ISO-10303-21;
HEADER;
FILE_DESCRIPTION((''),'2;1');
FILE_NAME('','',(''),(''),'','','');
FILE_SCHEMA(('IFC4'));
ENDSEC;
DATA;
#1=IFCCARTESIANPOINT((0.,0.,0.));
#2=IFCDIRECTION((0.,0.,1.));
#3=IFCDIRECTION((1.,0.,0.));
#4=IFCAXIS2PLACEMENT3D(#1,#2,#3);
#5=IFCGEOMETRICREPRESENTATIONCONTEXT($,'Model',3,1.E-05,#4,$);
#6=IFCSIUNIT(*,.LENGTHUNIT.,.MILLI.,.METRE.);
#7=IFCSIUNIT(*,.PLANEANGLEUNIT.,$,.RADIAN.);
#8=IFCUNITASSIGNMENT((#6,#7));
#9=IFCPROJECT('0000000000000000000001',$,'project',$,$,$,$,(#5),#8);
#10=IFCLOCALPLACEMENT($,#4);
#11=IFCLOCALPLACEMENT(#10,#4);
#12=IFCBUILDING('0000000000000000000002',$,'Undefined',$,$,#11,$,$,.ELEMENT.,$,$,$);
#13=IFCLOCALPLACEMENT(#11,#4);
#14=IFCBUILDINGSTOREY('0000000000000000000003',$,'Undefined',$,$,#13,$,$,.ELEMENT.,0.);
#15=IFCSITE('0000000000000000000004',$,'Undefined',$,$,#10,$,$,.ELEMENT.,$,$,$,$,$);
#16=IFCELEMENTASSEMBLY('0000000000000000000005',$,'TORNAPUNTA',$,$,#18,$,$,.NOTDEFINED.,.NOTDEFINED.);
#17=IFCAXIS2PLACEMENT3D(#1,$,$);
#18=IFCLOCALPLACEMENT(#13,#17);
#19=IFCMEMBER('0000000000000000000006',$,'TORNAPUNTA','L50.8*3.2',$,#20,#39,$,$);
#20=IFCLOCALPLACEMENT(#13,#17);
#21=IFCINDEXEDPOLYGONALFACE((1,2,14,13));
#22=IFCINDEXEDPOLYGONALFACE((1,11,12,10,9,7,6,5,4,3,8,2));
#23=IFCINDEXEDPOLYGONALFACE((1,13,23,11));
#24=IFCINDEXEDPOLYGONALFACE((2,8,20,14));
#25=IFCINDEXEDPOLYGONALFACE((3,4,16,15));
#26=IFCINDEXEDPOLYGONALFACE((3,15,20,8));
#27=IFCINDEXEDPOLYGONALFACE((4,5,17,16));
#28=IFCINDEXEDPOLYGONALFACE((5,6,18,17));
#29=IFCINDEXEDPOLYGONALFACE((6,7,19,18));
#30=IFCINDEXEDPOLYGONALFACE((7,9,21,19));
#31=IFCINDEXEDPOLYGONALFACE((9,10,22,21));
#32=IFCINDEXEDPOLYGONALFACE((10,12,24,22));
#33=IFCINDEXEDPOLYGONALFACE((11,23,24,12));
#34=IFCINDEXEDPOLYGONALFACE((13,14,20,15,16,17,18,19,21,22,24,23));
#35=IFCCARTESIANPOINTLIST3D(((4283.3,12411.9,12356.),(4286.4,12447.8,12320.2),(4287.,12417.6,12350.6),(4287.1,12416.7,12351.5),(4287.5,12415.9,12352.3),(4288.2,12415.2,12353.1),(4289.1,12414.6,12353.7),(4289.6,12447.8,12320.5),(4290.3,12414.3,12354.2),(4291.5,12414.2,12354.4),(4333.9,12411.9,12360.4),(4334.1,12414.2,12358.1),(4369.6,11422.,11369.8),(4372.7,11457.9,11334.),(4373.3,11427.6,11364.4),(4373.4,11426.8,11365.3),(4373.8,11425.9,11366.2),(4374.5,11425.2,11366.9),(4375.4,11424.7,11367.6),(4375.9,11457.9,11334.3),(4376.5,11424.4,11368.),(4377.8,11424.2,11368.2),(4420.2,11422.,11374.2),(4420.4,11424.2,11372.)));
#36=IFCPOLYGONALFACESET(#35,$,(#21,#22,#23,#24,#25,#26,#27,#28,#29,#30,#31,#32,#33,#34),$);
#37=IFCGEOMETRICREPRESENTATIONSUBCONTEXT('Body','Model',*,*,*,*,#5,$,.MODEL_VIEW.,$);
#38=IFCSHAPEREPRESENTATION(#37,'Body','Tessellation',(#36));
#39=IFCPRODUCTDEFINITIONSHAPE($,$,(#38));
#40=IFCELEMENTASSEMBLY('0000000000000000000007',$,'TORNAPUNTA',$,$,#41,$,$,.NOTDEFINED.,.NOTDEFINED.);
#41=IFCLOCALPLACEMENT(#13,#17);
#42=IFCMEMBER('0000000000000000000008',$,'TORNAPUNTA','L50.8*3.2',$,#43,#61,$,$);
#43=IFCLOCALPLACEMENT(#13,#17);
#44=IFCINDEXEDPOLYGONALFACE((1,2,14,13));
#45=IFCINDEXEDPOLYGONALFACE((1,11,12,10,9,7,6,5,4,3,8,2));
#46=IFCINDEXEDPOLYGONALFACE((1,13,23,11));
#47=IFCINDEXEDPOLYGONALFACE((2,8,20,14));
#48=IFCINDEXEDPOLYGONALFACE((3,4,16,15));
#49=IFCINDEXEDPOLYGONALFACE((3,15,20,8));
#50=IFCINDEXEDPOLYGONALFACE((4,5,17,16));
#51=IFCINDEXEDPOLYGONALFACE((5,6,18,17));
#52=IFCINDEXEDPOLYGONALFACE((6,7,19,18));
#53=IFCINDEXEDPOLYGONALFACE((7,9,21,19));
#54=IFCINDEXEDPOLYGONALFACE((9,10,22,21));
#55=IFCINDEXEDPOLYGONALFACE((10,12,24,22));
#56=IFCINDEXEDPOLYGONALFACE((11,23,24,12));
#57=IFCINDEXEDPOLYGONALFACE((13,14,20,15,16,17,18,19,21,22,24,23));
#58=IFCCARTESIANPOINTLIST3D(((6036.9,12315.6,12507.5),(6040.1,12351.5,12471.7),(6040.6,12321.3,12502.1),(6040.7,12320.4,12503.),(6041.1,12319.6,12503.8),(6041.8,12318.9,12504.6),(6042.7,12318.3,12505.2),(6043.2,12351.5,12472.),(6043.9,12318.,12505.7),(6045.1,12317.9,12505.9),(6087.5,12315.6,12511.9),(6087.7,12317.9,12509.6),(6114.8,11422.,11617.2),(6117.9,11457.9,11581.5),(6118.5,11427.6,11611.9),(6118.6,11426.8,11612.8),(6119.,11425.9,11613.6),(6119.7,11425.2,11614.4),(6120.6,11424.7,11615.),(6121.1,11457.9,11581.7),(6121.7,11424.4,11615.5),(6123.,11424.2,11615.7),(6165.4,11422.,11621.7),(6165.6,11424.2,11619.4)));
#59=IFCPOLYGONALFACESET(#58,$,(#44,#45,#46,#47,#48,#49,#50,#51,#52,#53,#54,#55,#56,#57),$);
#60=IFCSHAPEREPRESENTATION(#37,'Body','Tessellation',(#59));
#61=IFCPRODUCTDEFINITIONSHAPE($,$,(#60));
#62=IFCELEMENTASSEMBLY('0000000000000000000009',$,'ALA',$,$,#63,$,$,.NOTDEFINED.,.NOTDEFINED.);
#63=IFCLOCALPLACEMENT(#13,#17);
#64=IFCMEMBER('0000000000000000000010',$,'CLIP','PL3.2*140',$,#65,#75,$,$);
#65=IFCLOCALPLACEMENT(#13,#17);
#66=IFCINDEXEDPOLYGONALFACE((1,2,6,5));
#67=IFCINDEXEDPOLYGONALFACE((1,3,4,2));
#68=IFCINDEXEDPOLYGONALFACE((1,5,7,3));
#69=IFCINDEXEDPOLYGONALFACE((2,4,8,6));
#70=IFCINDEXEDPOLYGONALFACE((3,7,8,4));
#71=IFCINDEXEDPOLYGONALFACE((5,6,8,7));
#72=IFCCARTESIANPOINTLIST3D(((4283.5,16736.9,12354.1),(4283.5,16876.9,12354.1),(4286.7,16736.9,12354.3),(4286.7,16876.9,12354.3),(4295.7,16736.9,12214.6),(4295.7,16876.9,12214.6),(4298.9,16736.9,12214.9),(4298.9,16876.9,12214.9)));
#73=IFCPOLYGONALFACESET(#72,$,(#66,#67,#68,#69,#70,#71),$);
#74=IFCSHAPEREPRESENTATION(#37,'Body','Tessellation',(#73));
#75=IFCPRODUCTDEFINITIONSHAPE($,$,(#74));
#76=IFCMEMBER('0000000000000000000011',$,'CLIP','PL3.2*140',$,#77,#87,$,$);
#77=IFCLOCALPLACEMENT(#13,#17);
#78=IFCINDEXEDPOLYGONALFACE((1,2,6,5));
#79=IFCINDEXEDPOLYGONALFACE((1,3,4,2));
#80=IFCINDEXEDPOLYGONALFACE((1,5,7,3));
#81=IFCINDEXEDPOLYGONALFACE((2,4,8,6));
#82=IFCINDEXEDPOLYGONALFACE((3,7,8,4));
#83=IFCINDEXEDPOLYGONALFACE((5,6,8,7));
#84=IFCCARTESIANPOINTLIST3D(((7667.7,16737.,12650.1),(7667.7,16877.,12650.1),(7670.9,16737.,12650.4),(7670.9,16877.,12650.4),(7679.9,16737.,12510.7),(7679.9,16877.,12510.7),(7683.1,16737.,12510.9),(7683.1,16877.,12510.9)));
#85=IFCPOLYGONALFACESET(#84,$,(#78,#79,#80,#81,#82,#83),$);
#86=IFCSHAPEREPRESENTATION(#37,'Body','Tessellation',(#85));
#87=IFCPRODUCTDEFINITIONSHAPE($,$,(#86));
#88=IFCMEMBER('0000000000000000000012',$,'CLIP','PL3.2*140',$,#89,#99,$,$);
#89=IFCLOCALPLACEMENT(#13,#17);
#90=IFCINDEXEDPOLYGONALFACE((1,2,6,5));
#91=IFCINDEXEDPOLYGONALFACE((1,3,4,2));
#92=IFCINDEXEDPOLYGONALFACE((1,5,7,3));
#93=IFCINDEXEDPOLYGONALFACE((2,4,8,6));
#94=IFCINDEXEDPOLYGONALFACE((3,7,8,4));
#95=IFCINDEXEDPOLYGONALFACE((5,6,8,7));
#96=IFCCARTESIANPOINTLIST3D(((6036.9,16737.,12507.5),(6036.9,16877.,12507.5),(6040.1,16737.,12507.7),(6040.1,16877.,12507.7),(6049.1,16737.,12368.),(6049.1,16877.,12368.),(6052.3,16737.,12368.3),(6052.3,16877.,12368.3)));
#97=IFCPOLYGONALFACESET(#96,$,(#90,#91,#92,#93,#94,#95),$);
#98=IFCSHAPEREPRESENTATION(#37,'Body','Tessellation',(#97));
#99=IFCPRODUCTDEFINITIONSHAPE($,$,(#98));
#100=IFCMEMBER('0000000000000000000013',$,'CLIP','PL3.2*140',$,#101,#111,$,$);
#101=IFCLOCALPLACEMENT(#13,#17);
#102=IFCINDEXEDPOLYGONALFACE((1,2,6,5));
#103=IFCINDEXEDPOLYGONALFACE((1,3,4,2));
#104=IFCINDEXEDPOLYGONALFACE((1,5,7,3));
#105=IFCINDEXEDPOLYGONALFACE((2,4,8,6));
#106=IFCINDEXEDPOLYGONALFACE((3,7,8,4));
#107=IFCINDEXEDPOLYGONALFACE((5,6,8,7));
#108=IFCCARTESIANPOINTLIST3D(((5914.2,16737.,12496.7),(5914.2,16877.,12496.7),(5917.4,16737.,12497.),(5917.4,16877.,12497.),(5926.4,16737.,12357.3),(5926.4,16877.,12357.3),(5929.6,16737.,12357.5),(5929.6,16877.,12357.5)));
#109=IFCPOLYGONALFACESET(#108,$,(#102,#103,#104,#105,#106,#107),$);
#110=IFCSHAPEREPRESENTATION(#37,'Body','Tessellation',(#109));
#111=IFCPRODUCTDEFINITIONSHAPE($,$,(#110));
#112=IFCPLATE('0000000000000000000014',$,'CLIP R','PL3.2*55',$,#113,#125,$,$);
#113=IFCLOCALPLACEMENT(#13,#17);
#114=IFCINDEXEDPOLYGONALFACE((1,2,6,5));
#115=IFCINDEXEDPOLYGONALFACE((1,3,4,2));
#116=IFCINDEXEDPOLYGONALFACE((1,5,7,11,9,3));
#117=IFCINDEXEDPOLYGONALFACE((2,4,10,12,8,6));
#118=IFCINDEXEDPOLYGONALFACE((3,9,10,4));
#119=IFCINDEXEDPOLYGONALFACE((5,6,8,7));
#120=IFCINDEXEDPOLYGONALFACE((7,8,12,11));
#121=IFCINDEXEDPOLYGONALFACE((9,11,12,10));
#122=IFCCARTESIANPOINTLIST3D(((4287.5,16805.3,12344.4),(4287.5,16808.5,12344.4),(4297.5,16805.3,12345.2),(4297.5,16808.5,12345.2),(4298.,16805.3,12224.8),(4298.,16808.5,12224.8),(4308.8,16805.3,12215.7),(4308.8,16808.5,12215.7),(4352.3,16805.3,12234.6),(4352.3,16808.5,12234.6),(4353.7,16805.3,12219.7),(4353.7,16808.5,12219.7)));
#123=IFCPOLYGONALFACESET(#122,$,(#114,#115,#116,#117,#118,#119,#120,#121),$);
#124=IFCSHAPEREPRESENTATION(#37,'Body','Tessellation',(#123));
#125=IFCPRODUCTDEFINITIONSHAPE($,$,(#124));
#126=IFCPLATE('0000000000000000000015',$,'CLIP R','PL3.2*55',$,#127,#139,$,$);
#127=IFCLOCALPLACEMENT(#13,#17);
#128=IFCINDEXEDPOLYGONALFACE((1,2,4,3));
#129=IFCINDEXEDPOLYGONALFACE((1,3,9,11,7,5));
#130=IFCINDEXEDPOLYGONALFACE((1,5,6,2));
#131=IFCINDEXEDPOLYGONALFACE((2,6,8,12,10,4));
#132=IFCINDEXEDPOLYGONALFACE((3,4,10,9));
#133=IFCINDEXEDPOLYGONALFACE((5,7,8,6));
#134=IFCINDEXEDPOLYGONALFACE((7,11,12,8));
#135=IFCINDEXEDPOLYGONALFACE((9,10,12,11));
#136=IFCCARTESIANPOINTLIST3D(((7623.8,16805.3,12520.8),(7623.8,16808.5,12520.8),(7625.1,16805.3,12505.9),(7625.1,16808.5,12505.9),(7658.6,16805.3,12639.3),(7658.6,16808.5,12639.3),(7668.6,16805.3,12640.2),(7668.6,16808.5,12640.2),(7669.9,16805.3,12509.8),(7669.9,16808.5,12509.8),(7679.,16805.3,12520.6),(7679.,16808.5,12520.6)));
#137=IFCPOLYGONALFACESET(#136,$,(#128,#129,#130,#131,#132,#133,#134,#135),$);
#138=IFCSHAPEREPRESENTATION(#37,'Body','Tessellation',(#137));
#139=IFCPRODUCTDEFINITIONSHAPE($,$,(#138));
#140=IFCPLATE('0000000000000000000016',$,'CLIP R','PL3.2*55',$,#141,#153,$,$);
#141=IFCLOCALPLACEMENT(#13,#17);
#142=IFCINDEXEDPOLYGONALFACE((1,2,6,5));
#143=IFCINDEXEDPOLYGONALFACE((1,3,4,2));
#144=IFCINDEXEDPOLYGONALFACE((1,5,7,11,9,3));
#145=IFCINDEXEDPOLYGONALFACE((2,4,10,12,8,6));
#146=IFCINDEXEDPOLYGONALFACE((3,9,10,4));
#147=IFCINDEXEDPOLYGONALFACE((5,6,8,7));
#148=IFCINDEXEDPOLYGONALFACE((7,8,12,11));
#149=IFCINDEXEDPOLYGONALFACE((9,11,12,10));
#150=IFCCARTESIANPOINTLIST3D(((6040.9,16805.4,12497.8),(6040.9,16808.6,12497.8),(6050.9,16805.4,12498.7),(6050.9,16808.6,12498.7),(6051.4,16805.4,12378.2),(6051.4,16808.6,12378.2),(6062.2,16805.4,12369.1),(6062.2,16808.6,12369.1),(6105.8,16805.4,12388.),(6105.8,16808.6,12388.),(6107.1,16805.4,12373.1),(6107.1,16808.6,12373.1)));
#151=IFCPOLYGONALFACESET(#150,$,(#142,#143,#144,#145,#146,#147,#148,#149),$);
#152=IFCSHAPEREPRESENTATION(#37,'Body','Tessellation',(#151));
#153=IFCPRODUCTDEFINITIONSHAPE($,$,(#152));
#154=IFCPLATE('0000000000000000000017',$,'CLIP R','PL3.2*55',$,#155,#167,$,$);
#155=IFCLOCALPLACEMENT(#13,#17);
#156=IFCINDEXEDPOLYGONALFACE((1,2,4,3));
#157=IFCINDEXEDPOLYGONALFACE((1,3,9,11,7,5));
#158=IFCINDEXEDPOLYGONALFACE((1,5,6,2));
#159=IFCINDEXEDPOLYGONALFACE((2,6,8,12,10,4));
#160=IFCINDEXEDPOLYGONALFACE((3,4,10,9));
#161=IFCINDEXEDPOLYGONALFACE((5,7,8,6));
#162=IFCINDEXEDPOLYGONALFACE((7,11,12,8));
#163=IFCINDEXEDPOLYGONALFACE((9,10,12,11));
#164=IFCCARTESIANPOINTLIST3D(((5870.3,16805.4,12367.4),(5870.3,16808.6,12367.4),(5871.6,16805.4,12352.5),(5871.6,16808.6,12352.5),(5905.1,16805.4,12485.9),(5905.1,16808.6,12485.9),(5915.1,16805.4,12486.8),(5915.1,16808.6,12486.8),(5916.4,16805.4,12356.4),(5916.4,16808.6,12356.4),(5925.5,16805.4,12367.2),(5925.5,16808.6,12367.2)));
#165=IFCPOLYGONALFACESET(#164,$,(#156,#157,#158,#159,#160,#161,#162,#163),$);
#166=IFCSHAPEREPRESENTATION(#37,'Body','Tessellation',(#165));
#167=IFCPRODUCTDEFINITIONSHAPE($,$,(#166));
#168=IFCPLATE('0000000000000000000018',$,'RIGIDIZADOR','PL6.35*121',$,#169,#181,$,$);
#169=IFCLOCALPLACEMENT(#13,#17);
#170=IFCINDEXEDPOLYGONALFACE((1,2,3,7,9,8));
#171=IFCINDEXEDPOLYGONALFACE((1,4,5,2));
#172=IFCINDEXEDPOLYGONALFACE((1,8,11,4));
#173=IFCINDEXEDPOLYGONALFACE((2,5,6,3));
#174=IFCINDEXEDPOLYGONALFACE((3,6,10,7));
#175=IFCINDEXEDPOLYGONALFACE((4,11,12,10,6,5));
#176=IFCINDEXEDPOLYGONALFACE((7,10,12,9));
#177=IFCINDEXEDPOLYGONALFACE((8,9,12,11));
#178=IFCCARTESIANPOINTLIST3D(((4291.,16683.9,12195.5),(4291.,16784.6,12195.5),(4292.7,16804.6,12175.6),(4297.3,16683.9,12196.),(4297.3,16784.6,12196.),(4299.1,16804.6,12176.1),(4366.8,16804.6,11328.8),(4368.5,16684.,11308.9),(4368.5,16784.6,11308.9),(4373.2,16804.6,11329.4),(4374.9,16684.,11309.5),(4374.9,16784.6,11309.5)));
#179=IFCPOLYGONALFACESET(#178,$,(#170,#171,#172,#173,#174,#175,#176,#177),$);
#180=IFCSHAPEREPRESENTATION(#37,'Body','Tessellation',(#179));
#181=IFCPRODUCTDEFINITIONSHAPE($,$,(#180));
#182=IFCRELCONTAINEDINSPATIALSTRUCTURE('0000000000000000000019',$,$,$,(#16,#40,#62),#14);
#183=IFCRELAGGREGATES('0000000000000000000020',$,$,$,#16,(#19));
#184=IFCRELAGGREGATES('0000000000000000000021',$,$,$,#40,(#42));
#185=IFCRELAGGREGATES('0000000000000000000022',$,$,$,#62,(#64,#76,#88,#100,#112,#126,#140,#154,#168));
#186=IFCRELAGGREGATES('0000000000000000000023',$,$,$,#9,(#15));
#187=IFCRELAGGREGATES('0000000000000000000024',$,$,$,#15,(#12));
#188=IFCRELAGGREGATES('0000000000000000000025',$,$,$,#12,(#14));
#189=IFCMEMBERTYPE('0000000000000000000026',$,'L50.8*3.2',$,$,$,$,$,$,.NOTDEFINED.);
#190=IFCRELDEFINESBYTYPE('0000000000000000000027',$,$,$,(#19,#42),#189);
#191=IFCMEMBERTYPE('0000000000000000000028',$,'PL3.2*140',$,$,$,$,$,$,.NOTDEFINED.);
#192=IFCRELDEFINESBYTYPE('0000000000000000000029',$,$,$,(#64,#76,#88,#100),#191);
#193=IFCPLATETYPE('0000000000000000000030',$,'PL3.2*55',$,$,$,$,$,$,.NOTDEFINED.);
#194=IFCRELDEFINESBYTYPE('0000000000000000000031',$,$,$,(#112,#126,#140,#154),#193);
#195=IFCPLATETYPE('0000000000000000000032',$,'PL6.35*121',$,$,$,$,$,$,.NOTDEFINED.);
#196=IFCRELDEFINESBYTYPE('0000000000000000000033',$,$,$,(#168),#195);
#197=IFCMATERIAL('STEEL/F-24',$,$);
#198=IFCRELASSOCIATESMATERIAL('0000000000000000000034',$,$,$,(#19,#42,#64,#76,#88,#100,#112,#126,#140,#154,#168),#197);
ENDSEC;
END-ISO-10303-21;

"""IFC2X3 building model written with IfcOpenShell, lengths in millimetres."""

from ifc_helpers import new_model, si_unit, frame, origin_with_axes, origin_2d_with_axis, place, context, subcontext, project, spatial, polyline, rectangle, l_section, outline, extrude, material, type_object, element, aggregate, save


model = new_model("IFC2X3")

# Units and contexts
model_context = context("Model", 3, precision=1e-05, world=origin_with_axes())
body_context = subcontext(model_context, "Body", "Model", "MODEL_VIEW")
ifc_project = project(units=[si_unit("LENGTHUNIT", "METRE", prefix="MILLI"), si_unit("PLANEANGLEUNIT", "RADIAN")], contexts=[model_context])

# Site, building, storey
site_placement = place(None, origin_with_axes())
site = spatial("IfcSite", under=ifc_project, at=site_placement, Name="Undefined", CompositionType="ELEMENT")
building_placement = place(site_placement, origin_with_axes())
building = spatial("IfcBuilding", under=site, at=building_placement, Name="Undefined", CompositionType="ELEMENT")
storey_placement = place(building_placement, origin_with_axes())
storey = spatial("IfcBuildingStorey", under=building, at=storey_placement, Name="Undefined", CompositionType="ELEMENT", Elevation=0.0)

# Element assemblies, members
assembly_1_placement = place(storey_placement, origin_with_axes())
assembly_1 = element("IfcElementAssembly", 1, at=assembly_1_placement, inside=storey, Name="TORNAPUNTA", AssemblyPlace="NOTDEFINED", PredefinedType="NOTDEFINED")
ifc_material_1 = material(Name="STEEL/F-24")
member_type_1 = type_object("IfcMemberType", Name="L50.8*3.2", PredefinedType="NOTDEFINED")
member_1_placement = place(assembly_1_placement, frame((4310.2, 12429.9, 12340.3), z_axis=(0.061628, 0.707107, -0.704416), x_axis=(0.061628, -0.707107, -0.704416)))
member_1 = element("IfcMember", 2, at=member_1_placement, type_object=member_type_1, material=ifc_material_1, Name="TORNAPUNTA", Description="L50.8*3.2", context=body_context, shape_type="SweptSolid", body=[
    extrude(l_section(Depth=50.8, Width=50.8, Thickness=3.2, FilletRadius=4.8, at=origin_2d_with_axis()), frame((1400.0, 0.0, 0.0), z_axis=(-1.0, 0.0, 0.0), x_axis=(0.0, -1.0, 0.0)), (0.0, 0.0, 1.0), 1400.0),
])
aggregate(assembly_1, [member_1])
assembly_2_placement = place(storey_placement, origin_with_axes())
assembly_2 = element("IfcElementAssembly", 3, at=assembly_2_placement, inside=storey, Name="TORNAPUNTA", AssemblyPlace="NOTDEFINED", PredefinedType="NOTDEFINED")
member_2_placement = place(assembly_2_placement, frame((6063.8, 12333.6, 12491.8), z_axis=(0.061628, 0.707107, -0.704416), x_axis=(0.061628, -0.707107, -0.704416)))
member_2 = element("IfcMember", 4, at=member_2_placement, type_object=member_type_1, material=ifc_material_1, Name="TORNAPUNTA", Description="L50.8*3.2", context=body_context, shape_type="SweptSolid", body=[
    extrude(l_section(Depth=50.8, Width=50.8, Thickness=3.2, FilletRadius=4.8, at=origin_2d_with_axis()), frame((1263.8, 0.0, 0.0), z_axis=(-1.0, 0.0, 0.0), x_axis=(0.0, -1.0, 0.0)), (0.0, 0.0, 1.0), 1263.8),
])
aggregate(assembly_2, [member_2])

# Element assembly, members
assembly_3_placement = place(storey_placement, origin_with_axes())
assembly_3 = element("IfcElementAssembly", 5, at=assembly_3_placement, inside=storey, Name="ALA", AssemblyPlace="NOTDEFINED", PredefinedType="NOTDEFINED")
member_type_2 = type_object("IfcMemberType", Name="PL3.2*140", PredefinedType="NOTDEFINED")
member_3_placement = place(assembly_3_placement, frame((4285.1, 16806.9, 12354.2), z_axis=(0.0, -1.0, 0.0), x_axis=(0.087155, 0.0, -0.996195)))
member_3 = element("IfcMember", 6, at=member_3_placement, type_object=member_type_2, material=ifc_material_1, Name="CLIP", Description="PL3.2*140", context=body_context, shape_type="SweptSolid", body=[
    extrude(rectangle(XDim=3.2, YDim=140.0, at=origin_2d_with_axis()), frame((140.0, 0.0, 0.0), z_axis=(-1.0, 0.0, 0.0), x_axis=(0.0, -1.0, 0.0)), (0.0, 0.0, 1.0), 140.0),
])
member_4_placement = place(assembly_3_placement, frame((7669.3, 16807.0, 12650.3), z_axis=(0.0, -1.0, 0.0), x_axis=(0.087155, 0.0, -0.996195)))
member_4 = element("IfcMember", 7, at=member_4_placement, type_object=member_type_2, material=ifc_material_1, Name="CLIP", Description="PL3.2*140", context=body_context, shape_type="SweptSolid", body=[
    extrude(rectangle(XDim=3.2, YDim=140.0, at=origin_2d_with_axis()), frame((140.0, 0.0, 0.0), z_axis=(-1.0, 0.0, 0.0), x_axis=(0.0, -1.0, 0.0)), (0.0, 0.0, 1.0), 140.0),
])
member_5_placement = place(assembly_3_placement, frame((6038.5, 16807.0, 12507.6), z_axis=(0.0, -1.0, 0.0), x_axis=(0.087155, 0.0, -0.996195)))
member_5 = element("IfcMember", 8, at=member_5_placement, type_object=member_type_2, material=ifc_material_1, Name="CLIP", Description="PL3.2*140", context=body_context, shape_type="SweptSolid", body=[
    extrude(rectangle(XDim=3.2, YDim=140.0, at=origin_2d_with_axis()), frame((140.0, 0.0, 0.0), z_axis=(-1.0, 0.0, 0.0), x_axis=(0.0, -1.0, 0.0)), (0.0, 0.0, 1.0), 140.0),
])
member_6_placement = place(assembly_3_placement, frame((5915.8, 16807.0, 12496.9), z_axis=(0.0, -1.0, 0.0), x_axis=(0.087155, 0.0, -0.996195)))
member_6 = element("IfcMember", 9, at=member_6_placement, type_object=member_type_2, material=ifc_material_1, Name="CLIP", Description="PL3.2*140", context=body_context, shape_type="SweptSolid", body=[
    extrude(rectangle(XDim=3.2, YDim=140.0, at=origin_2d_with_axis()), frame((140.0, 0.0, 0.0), z_axis=(-1.0, 0.0, 0.0), x_axis=(0.0, -1.0, 0.0)), (0.0, 0.0, 1.0), 140.0),
])

# Plates
plate_type_1 = type_object("IfcPlateType", Name="PL3.2*55", PredefinedType="NOTDEFINED")
plate_1_placement = place(assembly_3_placement, frame((4287.5, 16806.9, 12344.4), z_axis=(0.0, 1.0, 0.0), x_axis=(0.996195, 0.0, 0.087155)))
plate_1 = element("IfcPlate", 10, at=plate_1_placement, type_object=plate_type_1, material=ifc_material_1, Name="CLIP R", Description="PL3.2*55", context=body_context, shape_type="SweptSolid", body=[
    extrude(outline(polyline([(0.0, 0.0), (10.0, 0.0), (55.0, 115.0), (55.0, 130.0), (10.0, 130.0), (0.0, 120.0), (0.0, 0.0)])), frame((0.0, 0.0, -1.6), z_axis=(0.0, 0.0, 1.0), x_axis=(1.0, 0.0, 0.0)), (0.0, 0.0, 1.0), 3.2),
])
plate_2_placement = place(assembly_3_placement, frame((7668.6, 16806.9, 12640.2), z_axis=(0.0, -1.0, 0.0), x_axis=(-0.996195, 0.0, -0.087155)))
plate_2 = element("IfcPlate", 11, at=plate_2_placement, type_object=plate_type_1, material=ifc_material_1, Name="CLIP R", Description="PL3.2*55", context=body_context, shape_type="SweptSolid", body=[
    extrude(outline(polyline([(0.0, 0.0), (10.0, 0.0), (55.0, 115.0), (55.0, 130.0), (10.0, 130.0), (0.0, 120.0), (0.0, 0.0)])), frame((0.0, 0.0, -1.6), z_axis=(0.0, 0.0, 1.0), x_axis=(1.0, 0.0, 0.0)), (0.0, 0.0, 1.0), 3.2),
])
plate_3_placement = place(assembly_3_placement, frame((6040.9, 16807.0, 12497.8), z_axis=(0.0, 1.0, 0.0), x_axis=(0.996195, 0.0, 0.087155)))
plate_3 = element("IfcPlate", 12, at=plate_3_placement, type_object=plate_type_1, material=ifc_material_1, Name="CLIP R", Description="PL3.2*55", context=body_context, shape_type="SweptSolid", body=[
    extrude(outline(polyline([(0.0, 0.0), (10.0, 0.0), (55.0, 115.0), (55.0, 130.0), (10.0, 130.0), (0.0, 120.0), (0.0, 0.0)])), frame((0.0, 0.0, -1.6), z_axis=(0.0, 0.0, 1.0), x_axis=(1.0, 0.0, 0.0)), (0.0, 0.0, 1.0), 3.2),
])
plate_4_placement = place(assembly_3_placement, frame((5915.1, 16807.0, 12486.8), z_axis=(0.0, -1.0, 0.0), x_axis=(-0.996195, 0.0, -0.087155)))
plate_4 = element("IfcPlate", 13, at=plate_4_placement, type_object=plate_type_1, material=ifc_material_1, Name="CLIP R", Description="PL3.2*55", context=body_context, shape_type="SweptSolid", body=[
    extrude(outline(polyline([(0.0, 0.0), (10.0, 0.0), (55.0, 115.0), (55.0, 130.0), (10.0, 130.0), (0.0, 120.0), (0.0, 0.0)])), frame((0.0, 0.0, -1.6), z_axis=(0.0, 0.0, 1.0), x_axis=(1.0, 0.0, 0.0)), (0.0, 0.0, 1.0), 3.2),
])
plate_type_2 = type_object("IfcPlateType", Name="PL6.35*121", PredefinedType="NOTDEFINED")
plate_5_placement = place(assembly_3_placement, frame((4294.1, 16804.6, 12195.8), z_axis=(0.996192, 0.0, 0.087188), x_axis=(0.0, -1.0, 0.0)))
plate_5 = element("IfcPlate", 14, at=plate_5_placement, type_object=plate_type_2, material=ifc_material_1, Name="RIGIDIZADOR", Description="PL6.35*121", context=body_context, shape_type="SweptSolid", body=[
    extrude(outline(polyline([(0.0, 20.0), (20.0, 0.0), (120.6, 0.0), (120.6, 890.0), (20.0, 890.0), (0.0, 870.0), (0.0, 20.0)])), frame((0.0, 0.0, -3.2), z_axis=(0.0, 0.0, 1.0), x_axis=(1.0, 0.0, 0.0)), (0.0, 0.0, 1.0), 6.4),
])

aggregate(assembly_3, [member_3, member_4, member_5, member_6, plate_1, plate_2, plate_3, plate_4, plate_5])

save(model, "model.ifc")
